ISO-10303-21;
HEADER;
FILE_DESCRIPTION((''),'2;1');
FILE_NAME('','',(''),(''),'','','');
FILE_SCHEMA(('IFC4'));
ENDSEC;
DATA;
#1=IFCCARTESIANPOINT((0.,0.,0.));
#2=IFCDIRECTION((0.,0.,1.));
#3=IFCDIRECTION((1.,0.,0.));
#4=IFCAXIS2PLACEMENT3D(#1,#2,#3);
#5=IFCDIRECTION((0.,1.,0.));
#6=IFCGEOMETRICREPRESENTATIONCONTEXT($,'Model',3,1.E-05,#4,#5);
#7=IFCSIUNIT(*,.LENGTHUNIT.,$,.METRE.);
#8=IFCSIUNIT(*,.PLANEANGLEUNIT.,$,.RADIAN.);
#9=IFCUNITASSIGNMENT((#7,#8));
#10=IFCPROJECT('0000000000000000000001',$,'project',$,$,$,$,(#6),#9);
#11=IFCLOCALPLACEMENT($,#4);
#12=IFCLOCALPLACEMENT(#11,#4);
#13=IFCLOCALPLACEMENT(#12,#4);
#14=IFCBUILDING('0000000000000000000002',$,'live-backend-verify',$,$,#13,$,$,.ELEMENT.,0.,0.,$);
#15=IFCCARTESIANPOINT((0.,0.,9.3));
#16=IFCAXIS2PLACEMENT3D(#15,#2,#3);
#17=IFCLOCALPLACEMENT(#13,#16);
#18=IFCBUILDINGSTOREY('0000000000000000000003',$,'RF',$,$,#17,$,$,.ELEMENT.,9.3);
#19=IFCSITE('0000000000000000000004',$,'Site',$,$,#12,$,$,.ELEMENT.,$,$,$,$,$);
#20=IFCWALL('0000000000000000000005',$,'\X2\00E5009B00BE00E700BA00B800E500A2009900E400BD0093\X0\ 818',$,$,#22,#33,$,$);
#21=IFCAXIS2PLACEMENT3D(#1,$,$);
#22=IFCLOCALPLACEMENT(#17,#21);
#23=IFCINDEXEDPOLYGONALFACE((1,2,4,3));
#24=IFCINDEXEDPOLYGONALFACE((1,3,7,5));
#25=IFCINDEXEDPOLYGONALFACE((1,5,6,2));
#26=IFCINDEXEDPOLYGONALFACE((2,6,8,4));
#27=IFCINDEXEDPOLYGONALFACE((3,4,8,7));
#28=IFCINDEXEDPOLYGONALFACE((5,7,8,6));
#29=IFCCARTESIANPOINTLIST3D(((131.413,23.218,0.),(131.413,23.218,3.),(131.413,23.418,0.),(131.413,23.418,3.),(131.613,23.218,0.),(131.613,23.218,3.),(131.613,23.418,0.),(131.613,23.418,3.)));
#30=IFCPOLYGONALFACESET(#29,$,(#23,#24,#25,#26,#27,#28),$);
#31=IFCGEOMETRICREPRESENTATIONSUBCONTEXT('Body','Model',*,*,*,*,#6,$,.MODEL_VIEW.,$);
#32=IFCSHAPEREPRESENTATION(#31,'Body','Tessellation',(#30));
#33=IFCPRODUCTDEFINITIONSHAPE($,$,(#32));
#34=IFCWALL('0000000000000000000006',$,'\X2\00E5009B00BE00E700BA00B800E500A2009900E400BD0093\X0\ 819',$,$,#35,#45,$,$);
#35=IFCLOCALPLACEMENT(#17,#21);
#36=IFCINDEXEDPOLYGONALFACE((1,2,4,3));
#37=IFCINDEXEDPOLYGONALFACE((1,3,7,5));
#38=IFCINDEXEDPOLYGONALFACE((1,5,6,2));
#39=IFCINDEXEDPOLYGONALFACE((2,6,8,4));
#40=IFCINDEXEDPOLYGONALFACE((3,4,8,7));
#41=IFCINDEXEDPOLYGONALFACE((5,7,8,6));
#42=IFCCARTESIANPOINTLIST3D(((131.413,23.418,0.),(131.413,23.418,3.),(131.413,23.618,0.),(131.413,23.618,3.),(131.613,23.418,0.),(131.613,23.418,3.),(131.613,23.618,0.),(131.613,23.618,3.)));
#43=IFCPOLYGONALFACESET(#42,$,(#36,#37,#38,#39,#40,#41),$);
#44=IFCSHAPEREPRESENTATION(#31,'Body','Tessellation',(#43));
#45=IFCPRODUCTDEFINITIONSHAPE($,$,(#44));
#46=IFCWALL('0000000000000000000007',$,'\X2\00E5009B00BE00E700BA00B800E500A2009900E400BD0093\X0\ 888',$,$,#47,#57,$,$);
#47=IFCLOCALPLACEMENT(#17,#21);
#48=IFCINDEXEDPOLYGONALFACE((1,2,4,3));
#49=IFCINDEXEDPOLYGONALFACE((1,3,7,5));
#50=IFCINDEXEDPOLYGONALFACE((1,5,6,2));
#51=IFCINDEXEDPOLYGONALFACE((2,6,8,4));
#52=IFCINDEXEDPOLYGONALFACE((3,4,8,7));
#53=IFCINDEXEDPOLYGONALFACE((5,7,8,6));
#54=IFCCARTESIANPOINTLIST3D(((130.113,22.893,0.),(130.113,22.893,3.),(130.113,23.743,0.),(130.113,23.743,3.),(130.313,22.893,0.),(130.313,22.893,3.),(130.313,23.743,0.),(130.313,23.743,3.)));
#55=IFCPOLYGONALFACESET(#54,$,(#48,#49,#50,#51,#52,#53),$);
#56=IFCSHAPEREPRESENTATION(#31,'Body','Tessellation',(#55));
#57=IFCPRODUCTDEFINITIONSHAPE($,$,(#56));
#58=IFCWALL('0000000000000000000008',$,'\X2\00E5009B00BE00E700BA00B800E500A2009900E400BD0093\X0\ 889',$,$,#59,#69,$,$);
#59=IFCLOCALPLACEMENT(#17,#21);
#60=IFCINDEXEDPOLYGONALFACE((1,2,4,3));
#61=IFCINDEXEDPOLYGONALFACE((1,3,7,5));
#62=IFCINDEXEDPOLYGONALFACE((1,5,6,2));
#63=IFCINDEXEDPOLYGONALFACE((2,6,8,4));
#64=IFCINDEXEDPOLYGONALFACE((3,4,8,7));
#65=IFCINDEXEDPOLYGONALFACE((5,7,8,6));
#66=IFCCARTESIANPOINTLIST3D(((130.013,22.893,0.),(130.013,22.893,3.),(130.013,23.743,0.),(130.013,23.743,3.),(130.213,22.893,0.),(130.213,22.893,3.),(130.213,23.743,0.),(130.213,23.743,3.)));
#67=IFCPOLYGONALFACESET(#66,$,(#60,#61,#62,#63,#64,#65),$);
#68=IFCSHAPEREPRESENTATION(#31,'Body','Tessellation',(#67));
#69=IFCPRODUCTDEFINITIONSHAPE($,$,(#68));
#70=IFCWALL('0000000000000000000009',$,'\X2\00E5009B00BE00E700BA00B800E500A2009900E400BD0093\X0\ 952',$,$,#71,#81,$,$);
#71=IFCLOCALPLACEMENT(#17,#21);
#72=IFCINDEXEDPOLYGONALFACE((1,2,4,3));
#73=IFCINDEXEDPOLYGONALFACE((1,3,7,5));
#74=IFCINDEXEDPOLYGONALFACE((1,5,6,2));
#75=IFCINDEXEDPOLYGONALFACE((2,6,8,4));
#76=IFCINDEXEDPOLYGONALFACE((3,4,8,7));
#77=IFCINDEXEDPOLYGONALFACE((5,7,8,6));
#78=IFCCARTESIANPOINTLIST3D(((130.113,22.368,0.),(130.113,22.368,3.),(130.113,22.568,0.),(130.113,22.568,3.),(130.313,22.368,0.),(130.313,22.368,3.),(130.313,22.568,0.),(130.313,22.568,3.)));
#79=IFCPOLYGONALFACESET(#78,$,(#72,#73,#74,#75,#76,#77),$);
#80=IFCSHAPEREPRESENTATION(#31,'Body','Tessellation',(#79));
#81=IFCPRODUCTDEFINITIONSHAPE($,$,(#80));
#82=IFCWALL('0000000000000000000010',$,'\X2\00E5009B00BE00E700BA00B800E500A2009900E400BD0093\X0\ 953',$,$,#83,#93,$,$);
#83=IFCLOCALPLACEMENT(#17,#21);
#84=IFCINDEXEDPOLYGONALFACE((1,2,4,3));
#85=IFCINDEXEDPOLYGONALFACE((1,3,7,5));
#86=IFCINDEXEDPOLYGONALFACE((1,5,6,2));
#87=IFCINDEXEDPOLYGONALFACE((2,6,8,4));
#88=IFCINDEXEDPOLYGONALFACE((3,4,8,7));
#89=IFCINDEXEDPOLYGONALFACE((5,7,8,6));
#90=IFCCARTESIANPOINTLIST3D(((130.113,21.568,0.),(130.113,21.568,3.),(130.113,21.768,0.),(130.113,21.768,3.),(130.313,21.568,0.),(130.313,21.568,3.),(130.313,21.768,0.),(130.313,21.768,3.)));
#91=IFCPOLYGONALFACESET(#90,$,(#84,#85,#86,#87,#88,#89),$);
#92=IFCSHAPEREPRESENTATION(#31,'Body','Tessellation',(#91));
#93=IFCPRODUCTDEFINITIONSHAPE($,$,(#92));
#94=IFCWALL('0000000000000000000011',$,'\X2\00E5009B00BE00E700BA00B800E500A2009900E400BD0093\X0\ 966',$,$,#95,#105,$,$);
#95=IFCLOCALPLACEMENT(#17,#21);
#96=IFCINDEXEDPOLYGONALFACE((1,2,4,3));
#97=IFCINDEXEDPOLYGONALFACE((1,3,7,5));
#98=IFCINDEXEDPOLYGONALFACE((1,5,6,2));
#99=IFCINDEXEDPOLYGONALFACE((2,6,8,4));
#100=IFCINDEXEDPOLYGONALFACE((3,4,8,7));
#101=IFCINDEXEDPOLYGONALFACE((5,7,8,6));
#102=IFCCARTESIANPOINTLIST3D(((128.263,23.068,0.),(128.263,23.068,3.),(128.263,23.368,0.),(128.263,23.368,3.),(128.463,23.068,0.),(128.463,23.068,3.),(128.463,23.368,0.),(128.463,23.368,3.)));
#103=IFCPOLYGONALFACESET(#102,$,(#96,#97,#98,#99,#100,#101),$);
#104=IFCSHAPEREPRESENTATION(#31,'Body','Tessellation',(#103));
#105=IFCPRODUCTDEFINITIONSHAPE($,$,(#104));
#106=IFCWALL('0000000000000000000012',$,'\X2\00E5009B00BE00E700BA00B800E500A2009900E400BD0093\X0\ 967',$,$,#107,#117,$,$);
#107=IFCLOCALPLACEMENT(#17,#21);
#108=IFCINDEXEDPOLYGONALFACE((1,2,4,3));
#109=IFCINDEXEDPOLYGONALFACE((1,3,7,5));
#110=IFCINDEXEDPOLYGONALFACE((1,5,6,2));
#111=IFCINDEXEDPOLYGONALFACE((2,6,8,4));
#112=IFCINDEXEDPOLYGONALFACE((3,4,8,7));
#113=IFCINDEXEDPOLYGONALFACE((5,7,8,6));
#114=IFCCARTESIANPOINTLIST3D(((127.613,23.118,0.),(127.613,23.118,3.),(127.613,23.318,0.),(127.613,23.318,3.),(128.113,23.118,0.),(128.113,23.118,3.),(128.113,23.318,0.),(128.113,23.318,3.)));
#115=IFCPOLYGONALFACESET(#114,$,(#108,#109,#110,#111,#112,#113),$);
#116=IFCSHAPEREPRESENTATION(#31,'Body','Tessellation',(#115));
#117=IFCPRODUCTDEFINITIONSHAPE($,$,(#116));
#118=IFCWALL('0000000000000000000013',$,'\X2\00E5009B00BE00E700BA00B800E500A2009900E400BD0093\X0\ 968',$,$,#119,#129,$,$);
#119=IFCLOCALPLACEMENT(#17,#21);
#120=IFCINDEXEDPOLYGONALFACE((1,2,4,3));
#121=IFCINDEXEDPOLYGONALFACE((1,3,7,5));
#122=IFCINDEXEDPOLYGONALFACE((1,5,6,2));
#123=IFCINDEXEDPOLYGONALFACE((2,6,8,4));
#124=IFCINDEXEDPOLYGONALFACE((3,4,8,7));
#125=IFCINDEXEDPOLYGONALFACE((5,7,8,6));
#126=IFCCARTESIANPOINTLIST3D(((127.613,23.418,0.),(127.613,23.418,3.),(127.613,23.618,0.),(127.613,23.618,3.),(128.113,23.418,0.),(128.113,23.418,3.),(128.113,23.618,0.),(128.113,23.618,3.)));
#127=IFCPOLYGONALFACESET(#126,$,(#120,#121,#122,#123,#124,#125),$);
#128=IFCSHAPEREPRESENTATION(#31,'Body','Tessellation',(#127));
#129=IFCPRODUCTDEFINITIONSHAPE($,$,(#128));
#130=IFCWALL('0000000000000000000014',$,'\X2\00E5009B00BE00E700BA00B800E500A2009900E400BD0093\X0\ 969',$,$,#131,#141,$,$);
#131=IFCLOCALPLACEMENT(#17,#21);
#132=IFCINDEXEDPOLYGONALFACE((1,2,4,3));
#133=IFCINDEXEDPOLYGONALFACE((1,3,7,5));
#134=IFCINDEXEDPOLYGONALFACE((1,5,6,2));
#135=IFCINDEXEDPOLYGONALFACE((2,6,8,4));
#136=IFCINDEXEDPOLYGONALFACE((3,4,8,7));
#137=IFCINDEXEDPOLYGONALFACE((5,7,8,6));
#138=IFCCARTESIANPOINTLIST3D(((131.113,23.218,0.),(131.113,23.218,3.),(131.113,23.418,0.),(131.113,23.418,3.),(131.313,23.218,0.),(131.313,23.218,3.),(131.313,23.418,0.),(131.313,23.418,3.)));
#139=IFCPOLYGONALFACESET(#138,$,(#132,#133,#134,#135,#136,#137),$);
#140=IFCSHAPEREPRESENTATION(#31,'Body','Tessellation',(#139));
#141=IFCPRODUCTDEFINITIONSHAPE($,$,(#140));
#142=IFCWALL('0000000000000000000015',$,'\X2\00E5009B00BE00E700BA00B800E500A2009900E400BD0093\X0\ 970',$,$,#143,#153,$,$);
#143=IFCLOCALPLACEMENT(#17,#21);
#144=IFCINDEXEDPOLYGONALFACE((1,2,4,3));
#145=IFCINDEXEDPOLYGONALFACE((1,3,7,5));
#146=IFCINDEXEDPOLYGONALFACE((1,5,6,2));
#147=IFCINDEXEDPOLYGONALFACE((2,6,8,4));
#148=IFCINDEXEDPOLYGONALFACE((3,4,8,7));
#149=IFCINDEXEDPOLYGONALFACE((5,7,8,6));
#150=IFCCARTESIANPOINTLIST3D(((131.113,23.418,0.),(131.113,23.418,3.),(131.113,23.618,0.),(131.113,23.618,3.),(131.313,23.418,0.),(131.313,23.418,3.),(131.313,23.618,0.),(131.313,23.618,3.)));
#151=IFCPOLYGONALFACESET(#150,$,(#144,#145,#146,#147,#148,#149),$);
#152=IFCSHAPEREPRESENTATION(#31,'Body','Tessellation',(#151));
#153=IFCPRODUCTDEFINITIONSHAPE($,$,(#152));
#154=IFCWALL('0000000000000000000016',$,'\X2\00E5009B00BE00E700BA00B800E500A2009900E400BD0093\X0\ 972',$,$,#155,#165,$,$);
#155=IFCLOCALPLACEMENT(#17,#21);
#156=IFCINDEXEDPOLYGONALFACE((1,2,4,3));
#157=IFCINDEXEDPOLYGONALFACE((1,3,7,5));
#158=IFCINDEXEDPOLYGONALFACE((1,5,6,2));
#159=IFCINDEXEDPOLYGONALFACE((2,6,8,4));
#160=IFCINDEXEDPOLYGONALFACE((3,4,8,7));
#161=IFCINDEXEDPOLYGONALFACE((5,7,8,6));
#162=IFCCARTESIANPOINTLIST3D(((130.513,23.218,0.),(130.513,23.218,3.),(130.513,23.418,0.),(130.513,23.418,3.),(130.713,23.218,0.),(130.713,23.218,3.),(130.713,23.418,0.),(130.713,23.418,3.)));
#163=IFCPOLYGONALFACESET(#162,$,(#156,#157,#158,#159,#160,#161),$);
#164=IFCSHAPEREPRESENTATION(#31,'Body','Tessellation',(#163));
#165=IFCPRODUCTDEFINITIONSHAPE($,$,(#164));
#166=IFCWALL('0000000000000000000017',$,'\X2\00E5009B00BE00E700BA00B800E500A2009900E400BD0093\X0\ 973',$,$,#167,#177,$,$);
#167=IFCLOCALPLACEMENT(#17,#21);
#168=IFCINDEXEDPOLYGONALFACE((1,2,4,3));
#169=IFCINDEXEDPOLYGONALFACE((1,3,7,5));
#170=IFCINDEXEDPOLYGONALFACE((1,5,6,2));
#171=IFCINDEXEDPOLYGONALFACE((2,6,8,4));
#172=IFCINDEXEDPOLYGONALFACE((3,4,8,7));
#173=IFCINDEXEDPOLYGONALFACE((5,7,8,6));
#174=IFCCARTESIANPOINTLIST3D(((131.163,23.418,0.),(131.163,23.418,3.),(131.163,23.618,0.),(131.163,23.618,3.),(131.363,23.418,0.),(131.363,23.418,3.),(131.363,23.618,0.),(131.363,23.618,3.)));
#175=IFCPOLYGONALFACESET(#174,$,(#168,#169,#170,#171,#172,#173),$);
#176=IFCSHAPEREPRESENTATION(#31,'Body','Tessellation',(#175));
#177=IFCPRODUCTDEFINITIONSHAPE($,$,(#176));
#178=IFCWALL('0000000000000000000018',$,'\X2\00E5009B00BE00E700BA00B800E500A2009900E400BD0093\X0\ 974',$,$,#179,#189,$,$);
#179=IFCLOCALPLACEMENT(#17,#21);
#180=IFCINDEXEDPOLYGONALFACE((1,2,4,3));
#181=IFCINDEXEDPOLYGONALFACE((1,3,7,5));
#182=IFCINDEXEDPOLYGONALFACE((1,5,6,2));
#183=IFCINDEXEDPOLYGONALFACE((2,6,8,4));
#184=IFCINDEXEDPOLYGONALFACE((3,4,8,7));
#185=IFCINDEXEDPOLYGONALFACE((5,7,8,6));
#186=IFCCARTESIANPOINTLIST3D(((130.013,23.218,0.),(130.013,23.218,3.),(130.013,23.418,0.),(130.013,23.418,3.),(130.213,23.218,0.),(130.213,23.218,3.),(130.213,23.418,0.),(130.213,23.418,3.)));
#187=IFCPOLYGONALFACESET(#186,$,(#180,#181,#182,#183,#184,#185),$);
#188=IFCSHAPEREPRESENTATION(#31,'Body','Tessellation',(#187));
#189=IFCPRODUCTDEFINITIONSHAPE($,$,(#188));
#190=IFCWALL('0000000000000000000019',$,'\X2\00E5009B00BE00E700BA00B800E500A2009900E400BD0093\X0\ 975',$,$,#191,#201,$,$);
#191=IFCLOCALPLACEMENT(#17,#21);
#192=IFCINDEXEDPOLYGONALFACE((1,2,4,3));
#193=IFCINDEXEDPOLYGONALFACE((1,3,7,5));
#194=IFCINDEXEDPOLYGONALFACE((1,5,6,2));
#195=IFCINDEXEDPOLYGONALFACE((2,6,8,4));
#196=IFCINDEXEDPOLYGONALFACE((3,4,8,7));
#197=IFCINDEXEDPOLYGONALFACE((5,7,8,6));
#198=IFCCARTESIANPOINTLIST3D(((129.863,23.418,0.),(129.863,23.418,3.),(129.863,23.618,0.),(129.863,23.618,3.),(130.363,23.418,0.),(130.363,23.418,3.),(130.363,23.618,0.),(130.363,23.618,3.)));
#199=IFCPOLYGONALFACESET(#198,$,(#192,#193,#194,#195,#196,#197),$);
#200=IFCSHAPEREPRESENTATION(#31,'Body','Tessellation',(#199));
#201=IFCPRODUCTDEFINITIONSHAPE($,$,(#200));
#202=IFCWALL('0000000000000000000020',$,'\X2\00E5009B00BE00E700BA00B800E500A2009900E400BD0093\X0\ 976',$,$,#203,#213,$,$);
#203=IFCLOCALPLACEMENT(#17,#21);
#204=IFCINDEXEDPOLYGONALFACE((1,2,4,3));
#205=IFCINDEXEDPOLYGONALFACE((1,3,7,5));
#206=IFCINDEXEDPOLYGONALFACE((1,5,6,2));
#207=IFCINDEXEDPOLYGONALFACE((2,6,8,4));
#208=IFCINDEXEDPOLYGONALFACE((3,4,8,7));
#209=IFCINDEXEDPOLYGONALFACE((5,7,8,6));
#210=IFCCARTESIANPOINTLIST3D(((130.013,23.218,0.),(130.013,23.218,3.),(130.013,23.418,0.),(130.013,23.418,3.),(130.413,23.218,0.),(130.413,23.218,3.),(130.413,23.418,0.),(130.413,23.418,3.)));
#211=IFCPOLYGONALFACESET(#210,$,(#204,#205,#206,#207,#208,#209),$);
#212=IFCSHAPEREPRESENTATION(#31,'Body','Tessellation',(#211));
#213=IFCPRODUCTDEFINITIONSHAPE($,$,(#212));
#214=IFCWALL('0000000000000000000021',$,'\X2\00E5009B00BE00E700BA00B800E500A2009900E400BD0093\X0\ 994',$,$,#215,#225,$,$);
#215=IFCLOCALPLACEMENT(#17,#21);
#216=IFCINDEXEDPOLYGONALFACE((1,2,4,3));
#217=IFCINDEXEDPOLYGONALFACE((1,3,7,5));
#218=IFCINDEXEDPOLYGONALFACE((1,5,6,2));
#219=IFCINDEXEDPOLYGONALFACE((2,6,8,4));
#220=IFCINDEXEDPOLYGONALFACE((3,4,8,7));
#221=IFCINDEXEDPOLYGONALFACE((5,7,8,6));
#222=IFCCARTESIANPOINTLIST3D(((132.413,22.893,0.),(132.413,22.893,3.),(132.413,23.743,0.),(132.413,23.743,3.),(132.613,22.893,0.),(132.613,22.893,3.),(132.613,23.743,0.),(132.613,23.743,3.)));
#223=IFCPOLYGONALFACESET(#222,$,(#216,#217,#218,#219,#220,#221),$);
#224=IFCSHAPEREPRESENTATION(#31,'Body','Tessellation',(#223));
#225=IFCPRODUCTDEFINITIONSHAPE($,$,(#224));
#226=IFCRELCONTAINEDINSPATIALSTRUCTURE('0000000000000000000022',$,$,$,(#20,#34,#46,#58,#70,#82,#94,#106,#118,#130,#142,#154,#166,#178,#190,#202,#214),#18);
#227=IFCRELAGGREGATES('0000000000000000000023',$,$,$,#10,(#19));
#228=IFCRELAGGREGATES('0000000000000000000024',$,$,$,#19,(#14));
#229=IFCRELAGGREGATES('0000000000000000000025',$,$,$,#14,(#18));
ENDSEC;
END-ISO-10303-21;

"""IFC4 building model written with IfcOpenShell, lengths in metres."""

from ifc_helpers import new_model, si_unit, direction, frame, frame_2d, origin_with_axes, place, context, subcontext, project, spatial, rectangle, extrude, element, save


model = new_model("IFC4")

# Units and contexts
model_context = context("Model", 3, precision=1e-05, world=origin_with_axes(), true_north=direction((0.0, 1.0, 0.0)))
body_context = subcontext(model_context, "Body", "Model", "MODEL_VIEW")
ifc_project = project(units=[si_unit("LENGTHUNIT", "METRE"), si_unit("PLANEANGLEUNIT", "RADIAN")], contexts=[model_context])

# Site, building, storey
placement = place(None, origin_with_axes())
site_placement = place(placement, origin_with_axes())
site = spatial("IfcSite", under=ifc_project, at=site_placement, Name="Site", CompositionType="ELEMENT")
building_placement = place(site_placement, origin_with_axes())
building = spatial("IfcBuilding", under=site, at=building_placement, Name="live-backend-verify", CompositionType="ELEMENT", ElevationOfRefHeight=0.0, ElevationOfTerrain=0.0)
storey_placement = place(building_placement, frame((0.0, 0.0, 9.3), z_axis=(0.0, 0.0, 1.0), x_axis=(1.0, 0.0, 0.0)))
storey = spatial("IfcBuildingStorey", under=building, at=storey_placement, Name="RF", CompositionType="ELEMENT", Elevation=9.3)

# Walls
for number, where, z_axis, x_axis, name in (
    (1, (131.513, 23.318, 0.0), (0.0, 0.0, 1.0), (-1.0, 0.0, 0.0), "å\u009b¾çº¸å¢\u0099ä½\u0093 818"),
    (2, (131.513, 23.518, 0.0), (0.0, 0.0, 1.0), (-1.0, 0.0, 0.0), "å\u009b¾çº¸å¢\u0099ä½\u0093 819"),
):
    element("IfcWall", number, at=place(storey_placement, frame(where, z_axis=z_axis, x_axis=x_axis)), inside=storey, Name=name, context=body_context, shape_type="SweptSolid", body=[
        extrude(rectangle(XDim=0.2, YDim=0.2, at=frame_2d((0.0, 0.0), x_axis=(1.0, 0.0, 0.0))), frame((0.0, 0.0, 0.0), z_axis=(0.0, 0.0, 1.0)), (0.0, 0.0, 1.0), 3.0),
    ])
for number, where, z_axis, x_axis, name in (
    (3, (130.213, 23.318, 0.0), (0.0, 0.0, 1.0), (0.0, -1.0, 0.0), "å\u009b¾çº¸å¢\u0099ä½\u0093 888"),
    (4, (130.113, 23.318, 0.0), (0.0, 0.0, 1.0), (0.0, -1.0, 0.0), "å\u009b¾çº¸å¢\u0099ä½\u0093 889"),
):
    element("IfcWall", number, at=place(storey_placement, frame(where, z_axis=z_axis, x_axis=x_axis)), inside=storey, Name=name, context=body_context, shape_type="SweptSolid", body=[
        extrude(rectangle(XDim=0.85, YDim=0.2, at=frame_2d((0.0, 0.0), x_axis=(1.0, 0.0, 0.0))), frame((0.0, 0.0, 0.0), z_axis=(0.0, 0.0, 1.0)), (0.0, 0.0, 1.0), 3.0),
    ])
for number, where, z_axis, x_axis, name in (
    (5, (130.213, 22.468, 0.0), (0.0, 0.0, 1.0), (-1.0, 0.0, 0.0), "å\u009b¾çº¸å¢\u0099ä½\u0093 952"),
    (6, (130.213, 21.668, 0.0), (0.0, 0.0, 1.0), (0.0, -1.0, 0.0), "å\u009b¾çº¸å¢\u0099ä½\u0093 953"),
):
    element("IfcWall", number, at=place(storey_placement, frame(where, z_axis=z_axis, x_axis=x_axis)), inside=storey, Name=name, context=body_context, shape_type="SweptSolid", body=[
        extrude(rectangle(XDim=0.2, YDim=0.2, at=frame_2d((0.0, 0.0), x_axis=(1.0, 0.0, 0.0))), frame((0.0, 0.0, 0.0), z_axis=(0.0, 0.0, 1.0)), (0.0, 0.0, 1.0), 3.0),
    ])
wall_1_placement = place(storey_placement, frame((128.363, 23.218, 0.0), z_axis=(0.0, 0.0, 1.0), x_axis=(0.0, 1.0, 0.0)))
element("IfcWall", 7, at=wall_1_placement, inside=storey, Name="å\u009b¾çº¸å¢\u0099ä½\u0093 966", context=body_context, shape_type="SweptSolid", body=[
    extrude(rectangle(XDim=0.3, YDim=0.2, at=frame_2d((0.0, 0.0), x_axis=(1.0, 0.0, 0.0))), frame((0.0, 0.0, 0.0), z_axis=(0.0, 0.0, 1.0)), (0.0, 0.0, 1.0), 3.0),
])
for number, where, z_axis, x_axis, name in (
    (8, (127.863, 23.218, 0.0), (0.0, 0.0, 1.0), (1.0, 0.0, 0.0), "å\u009b¾çº¸å¢\u0099ä½\u0093 967"),
    (9, (127.863, 23.518, 0.0), (0.0, 0.0, 1.0), (1.0, 0.0, 0.0), "å\u009b¾çº¸å¢\u0099ä½\u0093 968"),
):
    element("IfcWall", number, at=place(storey_placement, frame(where, z_axis=z_axis, x_axis=x_axis)), inside=storey, Name=name, context=body_context, shape_type="SweptSolid", body=[
        extrude(rectangle(XDim=0.5, YDim=0.2, at=frame_2d((0.0, 0.0), x_axis=(1.0, 0.0, 0.0))), frame((0.0, 0.0, 0.0), z_axis=(0.0, 0.0, 1.0)), (0.0, 0.0, 1.0), 3.0),
    ])
for number, where, z_axis, x_axis, name in (
    (10, (131.213, 23.318, 0.0), (0.0, 0.0, 1.0), (1.0, 0.0, 0.0), "å\u009b¾çº¸å¢\u0099ä½\u0093 969"),
    (11, (131.213, 23.518, 0.0), (0.0, 0.0, 1.0), (1.0, 0.0, 0.0), "å\u009b¾çº¸å¢\u0099ä½\u0093 970"),
    (12, (130.613, 23.318, 0.0), (0.0, 0.0, 1.0), (0.0, 1.0, 0.0), "å\u009b¾çº¸å¢\u0099ä½\u0093 972"),
    (13, (131.263, 23.518, 0.0), (0.0, 0.0, 1.0), (1.0, 0.0, 0.0), "å\u009b¾çº¸å¢\u0099ä½\u0093 973"),
    (14, (130.113, 23.318, 0.0), (0.0, 0.0, 1.0), (0.0, 1.0, 0.0), "å\u009b¾çº¸å¢\u0099ä½\u0093 974"),
):
    element("IfcWall", number, at=place(storey_placement, frame(where, z_axis=z_axis, x_axis=x_axis)), inside=storey, Name=name, context=body_context, shape_type="SweptSolid", body=[
        extrude(rectangle(XDim=0.2, YDim=0.2, at=frame_2d((0.0, 0.0), x_axis=(1.0, 0.0, 0.0))), frame((0.0, 0.0, 0.0), z_axis=(0.0, 0.0, 1.0)), (0.0, 0.0, 1.0), 3.0),
    ])
wall_2_placement = place(storey_placement, frame((130.113, 23.518, 0.0), z_axis=(0.0, 0.0, 1.0), x_axis=(1.0, 0.0, 0.0)))
element("IfcWall", 15, at=wall_2_placement, inside=storey, Name="å\u009b¾çº¸å¢\u0099ä½\u0093 975", context=body_context, shape_type="SweptSolid", body=[
    extrude(rectangle(XDim=0.5, YDim=0.2, at=frame_2d((0.0, 0.0), x_axis=(1.0, 0.0, 0.0))), frame((0.0, 0.0, 0.0), z_axis=(0.0, 0.0, 1.0)), (0.0, 0.0, 1.0), 3.0),
])
wall_3_placement = place(storey_placement, frame((130.213, 23.318, 0.0), z_axis=(0.0, 0.0, 1.0), x_axis=(1.0, 0.0, 0.0)))
element("IfcWall", 16, at=wall_3_placement, inside=storey, Name="å\u009b¾çº¸å¢\u0099ä½\u0093 976", context=body_context, shape_type="SweptSolid", body=[
    extrude(rectangle(XDim=0.4, YDim=0.2, at=frame_2d((0.0, 0.0), x_axis=(1.0, 0.0, 0.0))), frame((0.0, 0.0, 0.0), z_axis=(0.0, 0.0, 1.0)), (0.0, 0.0, 1.0), 3.0),
])
wall_4_placement = place(storey_placement, frame((132.513, 23.318, 0.0), z_axis=(0.0, 0.0, 1.0), x_axis=(0.0, -1.0, 0.0)))
element("IfcWall", 17, at=wall_4_placement, inside=storey, Name="å\u009b¾çº¸å¢\u0099ä½\u0093 994", context=body_context, shape_type="SweptSolid", body=[
    extrude(rectangle(XDim=0.85, YDim=0.2, at=frame_2d((0.0, 0.0), x_axis=(1.0, 0.0, 0.0))), frame((0.0, 0.0, 0.0), z_axis=(0.0, 0.0, 1.0)), (0.0, 0.0, 1.0), 3.0),
])

save(model, "model.ifc")
